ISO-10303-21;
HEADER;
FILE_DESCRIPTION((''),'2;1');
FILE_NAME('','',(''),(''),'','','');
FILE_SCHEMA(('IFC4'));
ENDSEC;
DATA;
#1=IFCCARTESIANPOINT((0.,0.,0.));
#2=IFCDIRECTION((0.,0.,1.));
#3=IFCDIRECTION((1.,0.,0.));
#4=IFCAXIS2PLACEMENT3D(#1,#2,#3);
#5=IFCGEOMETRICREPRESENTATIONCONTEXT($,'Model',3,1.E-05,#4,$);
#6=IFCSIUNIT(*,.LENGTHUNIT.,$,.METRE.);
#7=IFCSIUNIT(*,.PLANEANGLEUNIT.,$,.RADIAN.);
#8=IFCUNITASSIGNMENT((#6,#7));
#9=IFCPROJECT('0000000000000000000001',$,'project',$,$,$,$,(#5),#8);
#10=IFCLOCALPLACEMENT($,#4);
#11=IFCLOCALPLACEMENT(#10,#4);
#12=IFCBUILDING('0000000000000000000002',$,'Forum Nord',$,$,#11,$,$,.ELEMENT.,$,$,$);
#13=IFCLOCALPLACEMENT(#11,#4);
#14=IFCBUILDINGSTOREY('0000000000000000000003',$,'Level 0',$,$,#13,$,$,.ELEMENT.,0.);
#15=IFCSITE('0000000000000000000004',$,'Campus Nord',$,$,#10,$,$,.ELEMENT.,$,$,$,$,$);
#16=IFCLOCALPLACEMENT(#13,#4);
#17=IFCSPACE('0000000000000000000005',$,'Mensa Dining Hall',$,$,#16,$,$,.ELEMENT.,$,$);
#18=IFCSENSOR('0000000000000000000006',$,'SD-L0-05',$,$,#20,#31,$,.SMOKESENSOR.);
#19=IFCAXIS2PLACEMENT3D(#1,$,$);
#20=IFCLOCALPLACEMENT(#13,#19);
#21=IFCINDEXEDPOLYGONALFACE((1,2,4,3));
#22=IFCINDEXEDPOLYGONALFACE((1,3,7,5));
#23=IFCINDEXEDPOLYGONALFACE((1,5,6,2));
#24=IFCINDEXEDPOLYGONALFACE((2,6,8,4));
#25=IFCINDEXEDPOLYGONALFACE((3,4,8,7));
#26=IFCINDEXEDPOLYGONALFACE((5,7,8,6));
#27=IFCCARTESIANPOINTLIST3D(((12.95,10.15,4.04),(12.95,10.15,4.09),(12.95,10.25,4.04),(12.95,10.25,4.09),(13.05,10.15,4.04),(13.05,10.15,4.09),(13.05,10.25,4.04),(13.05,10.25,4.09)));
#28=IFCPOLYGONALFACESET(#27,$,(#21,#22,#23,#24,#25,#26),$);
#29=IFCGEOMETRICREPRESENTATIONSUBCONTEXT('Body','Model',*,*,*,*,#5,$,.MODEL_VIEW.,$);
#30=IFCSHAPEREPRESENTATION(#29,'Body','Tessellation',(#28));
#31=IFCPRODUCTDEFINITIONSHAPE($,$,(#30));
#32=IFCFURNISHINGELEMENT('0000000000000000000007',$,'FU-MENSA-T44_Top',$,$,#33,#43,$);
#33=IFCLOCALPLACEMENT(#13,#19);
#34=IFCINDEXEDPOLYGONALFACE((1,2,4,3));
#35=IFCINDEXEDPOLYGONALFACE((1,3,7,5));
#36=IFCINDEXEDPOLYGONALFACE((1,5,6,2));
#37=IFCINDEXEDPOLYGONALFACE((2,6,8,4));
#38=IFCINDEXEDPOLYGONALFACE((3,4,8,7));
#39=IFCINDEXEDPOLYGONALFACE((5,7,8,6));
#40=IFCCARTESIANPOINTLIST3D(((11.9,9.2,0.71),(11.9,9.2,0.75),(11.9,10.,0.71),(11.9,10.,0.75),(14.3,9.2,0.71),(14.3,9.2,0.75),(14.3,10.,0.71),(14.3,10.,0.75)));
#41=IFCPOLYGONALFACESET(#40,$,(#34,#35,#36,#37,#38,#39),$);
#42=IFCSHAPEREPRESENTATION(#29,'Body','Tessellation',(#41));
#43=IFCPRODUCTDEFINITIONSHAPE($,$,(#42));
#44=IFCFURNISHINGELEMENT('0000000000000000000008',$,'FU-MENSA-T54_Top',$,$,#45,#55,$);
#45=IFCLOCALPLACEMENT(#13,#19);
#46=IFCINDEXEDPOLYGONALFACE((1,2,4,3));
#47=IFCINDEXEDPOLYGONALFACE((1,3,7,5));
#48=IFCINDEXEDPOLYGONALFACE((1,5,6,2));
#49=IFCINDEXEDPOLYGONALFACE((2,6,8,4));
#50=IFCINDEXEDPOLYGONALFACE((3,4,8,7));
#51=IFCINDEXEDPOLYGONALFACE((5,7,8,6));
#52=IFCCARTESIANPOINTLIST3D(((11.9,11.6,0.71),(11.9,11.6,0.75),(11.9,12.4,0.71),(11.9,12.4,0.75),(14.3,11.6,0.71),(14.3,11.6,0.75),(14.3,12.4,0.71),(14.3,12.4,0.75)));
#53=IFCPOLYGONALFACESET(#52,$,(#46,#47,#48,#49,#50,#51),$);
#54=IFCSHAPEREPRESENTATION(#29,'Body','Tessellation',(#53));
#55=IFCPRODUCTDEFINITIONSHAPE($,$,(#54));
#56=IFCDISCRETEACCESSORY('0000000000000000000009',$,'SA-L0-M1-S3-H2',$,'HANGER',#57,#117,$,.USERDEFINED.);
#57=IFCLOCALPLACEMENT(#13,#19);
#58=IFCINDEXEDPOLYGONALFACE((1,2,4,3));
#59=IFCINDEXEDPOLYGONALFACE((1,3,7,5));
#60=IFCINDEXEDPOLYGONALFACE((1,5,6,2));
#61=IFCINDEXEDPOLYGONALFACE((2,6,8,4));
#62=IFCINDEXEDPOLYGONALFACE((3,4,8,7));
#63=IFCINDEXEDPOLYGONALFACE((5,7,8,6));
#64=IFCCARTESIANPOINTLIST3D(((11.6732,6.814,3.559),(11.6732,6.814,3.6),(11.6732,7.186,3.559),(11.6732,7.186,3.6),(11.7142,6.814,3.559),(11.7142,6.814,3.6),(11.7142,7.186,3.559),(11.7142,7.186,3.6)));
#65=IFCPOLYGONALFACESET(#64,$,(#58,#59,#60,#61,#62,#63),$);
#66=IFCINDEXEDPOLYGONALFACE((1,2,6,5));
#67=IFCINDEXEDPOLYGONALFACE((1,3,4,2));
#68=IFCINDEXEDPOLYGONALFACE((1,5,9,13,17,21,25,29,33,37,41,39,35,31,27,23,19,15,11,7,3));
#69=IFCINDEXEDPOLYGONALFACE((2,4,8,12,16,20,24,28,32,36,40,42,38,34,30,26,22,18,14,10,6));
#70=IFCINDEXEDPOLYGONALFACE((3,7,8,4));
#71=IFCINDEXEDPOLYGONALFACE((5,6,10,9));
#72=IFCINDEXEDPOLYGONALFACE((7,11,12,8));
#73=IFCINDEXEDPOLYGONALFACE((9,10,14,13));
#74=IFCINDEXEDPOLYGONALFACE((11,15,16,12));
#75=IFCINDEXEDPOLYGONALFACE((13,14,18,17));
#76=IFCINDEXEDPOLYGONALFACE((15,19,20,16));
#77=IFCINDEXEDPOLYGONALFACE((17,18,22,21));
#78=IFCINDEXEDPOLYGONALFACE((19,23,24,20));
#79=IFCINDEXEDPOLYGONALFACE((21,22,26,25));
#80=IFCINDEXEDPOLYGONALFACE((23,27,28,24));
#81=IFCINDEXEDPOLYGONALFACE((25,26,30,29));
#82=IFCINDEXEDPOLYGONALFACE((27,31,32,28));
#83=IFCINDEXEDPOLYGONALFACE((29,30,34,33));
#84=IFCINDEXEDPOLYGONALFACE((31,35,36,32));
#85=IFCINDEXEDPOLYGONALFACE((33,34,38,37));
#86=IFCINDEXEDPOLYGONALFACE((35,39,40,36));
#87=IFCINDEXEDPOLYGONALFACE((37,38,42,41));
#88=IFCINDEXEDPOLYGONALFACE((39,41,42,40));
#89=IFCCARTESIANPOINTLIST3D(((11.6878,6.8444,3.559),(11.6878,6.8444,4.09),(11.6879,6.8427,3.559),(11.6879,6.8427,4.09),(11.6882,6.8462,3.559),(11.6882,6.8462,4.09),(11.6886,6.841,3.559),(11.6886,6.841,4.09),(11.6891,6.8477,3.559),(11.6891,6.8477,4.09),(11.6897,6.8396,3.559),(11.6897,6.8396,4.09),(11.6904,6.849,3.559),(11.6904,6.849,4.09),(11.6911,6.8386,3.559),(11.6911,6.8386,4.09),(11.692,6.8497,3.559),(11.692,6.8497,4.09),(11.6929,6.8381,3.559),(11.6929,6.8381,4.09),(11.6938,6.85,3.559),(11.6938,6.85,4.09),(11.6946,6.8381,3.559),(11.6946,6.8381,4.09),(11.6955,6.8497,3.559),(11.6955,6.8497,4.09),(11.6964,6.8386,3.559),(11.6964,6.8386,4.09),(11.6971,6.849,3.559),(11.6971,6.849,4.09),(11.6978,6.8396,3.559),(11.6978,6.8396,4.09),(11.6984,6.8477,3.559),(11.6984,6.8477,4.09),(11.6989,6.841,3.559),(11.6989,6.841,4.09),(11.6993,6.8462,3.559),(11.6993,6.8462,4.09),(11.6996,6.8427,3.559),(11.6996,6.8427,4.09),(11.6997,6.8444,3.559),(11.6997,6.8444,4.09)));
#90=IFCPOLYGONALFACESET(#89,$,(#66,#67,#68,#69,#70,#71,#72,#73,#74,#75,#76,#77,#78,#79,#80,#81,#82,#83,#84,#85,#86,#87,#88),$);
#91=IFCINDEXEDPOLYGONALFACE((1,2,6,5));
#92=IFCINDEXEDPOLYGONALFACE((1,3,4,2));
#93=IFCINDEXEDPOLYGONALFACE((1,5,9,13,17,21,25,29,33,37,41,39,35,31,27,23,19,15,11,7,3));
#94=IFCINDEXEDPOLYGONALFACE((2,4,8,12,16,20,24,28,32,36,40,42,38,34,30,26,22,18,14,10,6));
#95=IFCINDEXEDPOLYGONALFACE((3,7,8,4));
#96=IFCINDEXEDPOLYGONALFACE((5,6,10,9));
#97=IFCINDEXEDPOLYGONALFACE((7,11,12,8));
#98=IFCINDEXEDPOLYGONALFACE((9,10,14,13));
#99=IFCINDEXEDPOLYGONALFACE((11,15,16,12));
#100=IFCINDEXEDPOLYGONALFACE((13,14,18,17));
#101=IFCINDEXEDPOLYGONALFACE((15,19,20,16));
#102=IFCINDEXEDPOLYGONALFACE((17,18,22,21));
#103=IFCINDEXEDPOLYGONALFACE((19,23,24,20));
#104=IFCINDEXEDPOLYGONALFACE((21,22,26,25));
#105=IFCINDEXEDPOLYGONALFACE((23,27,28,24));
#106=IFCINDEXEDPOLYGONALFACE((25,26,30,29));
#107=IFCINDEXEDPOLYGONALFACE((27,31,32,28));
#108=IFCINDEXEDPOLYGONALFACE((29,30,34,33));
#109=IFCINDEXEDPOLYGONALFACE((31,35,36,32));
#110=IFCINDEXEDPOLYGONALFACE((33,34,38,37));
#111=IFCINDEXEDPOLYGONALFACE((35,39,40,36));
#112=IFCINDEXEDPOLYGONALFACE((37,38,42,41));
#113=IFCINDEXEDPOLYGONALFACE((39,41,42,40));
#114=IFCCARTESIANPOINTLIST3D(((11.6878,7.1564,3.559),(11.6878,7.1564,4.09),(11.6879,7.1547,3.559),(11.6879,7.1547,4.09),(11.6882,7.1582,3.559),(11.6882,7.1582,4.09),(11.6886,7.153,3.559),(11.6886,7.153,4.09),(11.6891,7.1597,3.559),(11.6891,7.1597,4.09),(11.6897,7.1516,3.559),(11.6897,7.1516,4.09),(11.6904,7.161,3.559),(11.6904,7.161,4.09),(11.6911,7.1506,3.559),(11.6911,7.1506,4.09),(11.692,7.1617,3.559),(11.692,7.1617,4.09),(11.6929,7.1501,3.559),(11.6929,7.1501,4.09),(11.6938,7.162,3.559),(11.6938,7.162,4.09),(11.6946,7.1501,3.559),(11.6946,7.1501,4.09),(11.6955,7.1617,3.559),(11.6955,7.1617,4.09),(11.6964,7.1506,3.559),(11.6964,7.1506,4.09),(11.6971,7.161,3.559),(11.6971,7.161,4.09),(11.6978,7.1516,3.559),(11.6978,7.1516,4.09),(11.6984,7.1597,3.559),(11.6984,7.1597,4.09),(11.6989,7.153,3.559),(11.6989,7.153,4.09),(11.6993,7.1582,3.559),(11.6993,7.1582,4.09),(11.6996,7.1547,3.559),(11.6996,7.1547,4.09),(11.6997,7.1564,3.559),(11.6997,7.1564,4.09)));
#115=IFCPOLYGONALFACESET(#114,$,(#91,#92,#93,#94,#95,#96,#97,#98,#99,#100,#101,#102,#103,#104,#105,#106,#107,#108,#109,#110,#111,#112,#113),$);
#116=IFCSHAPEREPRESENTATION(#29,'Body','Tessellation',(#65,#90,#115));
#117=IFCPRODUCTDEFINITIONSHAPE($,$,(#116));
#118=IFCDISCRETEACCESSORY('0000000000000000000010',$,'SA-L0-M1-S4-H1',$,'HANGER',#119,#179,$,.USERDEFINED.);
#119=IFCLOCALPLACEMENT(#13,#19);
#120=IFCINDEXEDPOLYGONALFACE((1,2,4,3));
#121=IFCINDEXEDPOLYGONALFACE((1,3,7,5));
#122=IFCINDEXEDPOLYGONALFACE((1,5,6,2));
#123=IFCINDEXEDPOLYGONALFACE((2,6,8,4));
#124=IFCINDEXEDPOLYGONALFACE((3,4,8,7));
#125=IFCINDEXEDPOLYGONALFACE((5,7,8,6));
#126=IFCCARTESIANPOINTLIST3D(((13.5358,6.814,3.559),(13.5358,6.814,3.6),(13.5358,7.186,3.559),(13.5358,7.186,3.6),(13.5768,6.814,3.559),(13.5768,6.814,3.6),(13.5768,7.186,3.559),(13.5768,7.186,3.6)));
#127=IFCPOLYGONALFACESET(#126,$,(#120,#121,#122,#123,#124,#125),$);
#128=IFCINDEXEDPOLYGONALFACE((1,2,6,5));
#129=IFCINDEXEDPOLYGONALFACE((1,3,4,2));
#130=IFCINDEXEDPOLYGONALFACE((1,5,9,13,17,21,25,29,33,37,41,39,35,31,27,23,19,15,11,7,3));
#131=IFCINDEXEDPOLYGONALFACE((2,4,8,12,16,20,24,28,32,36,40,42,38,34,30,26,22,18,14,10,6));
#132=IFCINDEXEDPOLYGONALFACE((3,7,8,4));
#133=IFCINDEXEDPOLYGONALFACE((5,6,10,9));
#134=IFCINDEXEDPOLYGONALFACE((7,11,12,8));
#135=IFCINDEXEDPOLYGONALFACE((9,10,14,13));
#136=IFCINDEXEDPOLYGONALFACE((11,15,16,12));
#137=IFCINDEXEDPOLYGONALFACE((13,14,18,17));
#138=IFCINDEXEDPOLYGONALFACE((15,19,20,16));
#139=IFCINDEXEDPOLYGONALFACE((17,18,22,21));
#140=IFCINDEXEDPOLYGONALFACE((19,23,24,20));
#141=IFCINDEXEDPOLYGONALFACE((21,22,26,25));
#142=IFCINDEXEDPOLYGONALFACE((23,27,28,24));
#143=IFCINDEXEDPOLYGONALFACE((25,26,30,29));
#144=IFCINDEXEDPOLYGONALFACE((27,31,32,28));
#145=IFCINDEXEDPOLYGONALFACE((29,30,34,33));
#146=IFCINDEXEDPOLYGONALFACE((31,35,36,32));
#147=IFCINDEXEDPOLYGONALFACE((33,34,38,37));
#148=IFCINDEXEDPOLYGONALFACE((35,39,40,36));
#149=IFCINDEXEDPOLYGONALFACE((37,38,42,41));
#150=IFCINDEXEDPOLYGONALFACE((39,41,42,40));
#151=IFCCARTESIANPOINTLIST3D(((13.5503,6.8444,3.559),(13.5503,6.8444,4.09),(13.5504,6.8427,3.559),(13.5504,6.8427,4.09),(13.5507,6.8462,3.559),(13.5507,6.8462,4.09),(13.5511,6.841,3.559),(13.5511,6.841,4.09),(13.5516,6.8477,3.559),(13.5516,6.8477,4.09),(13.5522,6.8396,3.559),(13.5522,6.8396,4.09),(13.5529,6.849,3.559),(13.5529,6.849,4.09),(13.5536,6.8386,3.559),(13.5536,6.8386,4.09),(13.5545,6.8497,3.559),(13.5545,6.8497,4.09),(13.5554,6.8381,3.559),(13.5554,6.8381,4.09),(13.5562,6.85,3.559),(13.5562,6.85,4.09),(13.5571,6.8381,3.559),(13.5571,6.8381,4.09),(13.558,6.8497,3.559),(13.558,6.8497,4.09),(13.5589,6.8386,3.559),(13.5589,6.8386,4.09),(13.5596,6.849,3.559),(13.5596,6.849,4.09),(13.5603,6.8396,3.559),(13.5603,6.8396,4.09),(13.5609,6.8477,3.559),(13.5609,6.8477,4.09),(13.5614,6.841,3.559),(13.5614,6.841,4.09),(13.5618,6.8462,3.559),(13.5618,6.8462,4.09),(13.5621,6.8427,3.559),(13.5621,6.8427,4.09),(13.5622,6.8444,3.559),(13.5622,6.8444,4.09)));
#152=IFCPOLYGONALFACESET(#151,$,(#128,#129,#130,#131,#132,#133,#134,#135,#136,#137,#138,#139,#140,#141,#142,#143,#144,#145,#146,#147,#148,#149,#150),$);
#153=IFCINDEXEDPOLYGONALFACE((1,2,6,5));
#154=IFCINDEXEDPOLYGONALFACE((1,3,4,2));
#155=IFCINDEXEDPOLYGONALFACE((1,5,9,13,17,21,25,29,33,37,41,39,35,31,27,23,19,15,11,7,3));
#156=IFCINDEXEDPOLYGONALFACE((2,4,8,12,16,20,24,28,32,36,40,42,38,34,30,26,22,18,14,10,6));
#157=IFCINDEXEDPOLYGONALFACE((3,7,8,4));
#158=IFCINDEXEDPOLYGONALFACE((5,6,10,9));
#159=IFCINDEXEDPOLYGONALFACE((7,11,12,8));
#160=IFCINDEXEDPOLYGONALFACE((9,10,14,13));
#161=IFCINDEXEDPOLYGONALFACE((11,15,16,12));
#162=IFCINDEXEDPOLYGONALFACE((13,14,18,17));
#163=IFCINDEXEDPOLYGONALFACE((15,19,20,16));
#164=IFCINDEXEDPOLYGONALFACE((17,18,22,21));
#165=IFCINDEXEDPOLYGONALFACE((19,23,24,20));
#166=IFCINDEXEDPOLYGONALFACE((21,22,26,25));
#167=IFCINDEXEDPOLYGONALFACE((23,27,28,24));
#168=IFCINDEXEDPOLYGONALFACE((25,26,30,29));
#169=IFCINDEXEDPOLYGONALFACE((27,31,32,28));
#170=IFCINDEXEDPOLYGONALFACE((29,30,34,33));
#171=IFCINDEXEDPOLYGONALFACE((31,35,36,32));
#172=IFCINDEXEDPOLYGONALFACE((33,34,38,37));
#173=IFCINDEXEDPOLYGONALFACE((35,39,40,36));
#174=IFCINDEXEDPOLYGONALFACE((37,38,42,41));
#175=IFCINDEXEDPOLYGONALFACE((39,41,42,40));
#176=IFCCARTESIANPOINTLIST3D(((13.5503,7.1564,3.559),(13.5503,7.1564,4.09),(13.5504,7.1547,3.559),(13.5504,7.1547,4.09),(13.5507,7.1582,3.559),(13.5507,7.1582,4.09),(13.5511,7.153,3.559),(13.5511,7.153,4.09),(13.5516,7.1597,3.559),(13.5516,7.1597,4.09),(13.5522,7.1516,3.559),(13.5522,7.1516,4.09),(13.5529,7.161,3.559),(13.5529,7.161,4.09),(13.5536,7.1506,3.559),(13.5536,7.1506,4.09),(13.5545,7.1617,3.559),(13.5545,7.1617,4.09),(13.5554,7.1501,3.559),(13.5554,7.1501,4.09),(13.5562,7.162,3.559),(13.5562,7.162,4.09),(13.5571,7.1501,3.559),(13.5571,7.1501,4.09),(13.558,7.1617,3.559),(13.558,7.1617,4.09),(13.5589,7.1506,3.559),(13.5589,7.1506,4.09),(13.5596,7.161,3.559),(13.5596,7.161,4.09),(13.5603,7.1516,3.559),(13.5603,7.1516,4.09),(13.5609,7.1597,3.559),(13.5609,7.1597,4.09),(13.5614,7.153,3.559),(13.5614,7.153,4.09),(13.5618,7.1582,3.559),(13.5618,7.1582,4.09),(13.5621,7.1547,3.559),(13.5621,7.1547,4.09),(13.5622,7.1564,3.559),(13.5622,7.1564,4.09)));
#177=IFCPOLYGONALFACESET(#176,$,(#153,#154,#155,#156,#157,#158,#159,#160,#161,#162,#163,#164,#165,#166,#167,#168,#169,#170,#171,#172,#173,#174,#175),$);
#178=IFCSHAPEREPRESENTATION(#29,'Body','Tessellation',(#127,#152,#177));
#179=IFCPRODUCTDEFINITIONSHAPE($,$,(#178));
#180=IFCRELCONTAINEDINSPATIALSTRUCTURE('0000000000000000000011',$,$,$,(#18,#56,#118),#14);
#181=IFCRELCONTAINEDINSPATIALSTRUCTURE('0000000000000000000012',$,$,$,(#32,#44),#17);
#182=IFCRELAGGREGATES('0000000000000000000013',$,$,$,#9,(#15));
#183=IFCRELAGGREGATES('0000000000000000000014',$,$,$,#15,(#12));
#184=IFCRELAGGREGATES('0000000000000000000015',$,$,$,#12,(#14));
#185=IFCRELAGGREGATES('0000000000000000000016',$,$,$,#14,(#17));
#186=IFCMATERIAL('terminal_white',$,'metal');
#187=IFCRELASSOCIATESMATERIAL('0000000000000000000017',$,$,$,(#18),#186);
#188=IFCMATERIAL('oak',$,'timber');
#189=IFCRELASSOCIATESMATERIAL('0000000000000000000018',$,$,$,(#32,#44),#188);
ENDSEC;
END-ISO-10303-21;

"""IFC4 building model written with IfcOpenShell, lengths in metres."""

from ifc_helpers import new_model, si_unit, frame, frame_2d, origin_with_axes, origin_2d_with_axis, place, context, subcontext, project, spatial, rectangle, circle, extrude, material, element, save


model = new_model("IFC4")

# Units and contexts
model_context = context("Model", 3, precision=1e-05, world=origin_with_axes())
body_context = subcontext(model_context, "Body", "Model", "MODEL_VIEW")
ifc_project = project(units=[si_unit("LENGTHUNIT", "METRE"), si_unit("PLANEANGLEUNIT", "RADIAN")], contexts=[model_context])

# Site, building, storey
site_placement = place(None, origin_with_axes())
site = spatial("IfcSite", under=ifc_project, at=site_placement, Name="Campus Nord", CompositionType="ELEMENT")
building_placement = place(site_placement, origin_with_axes())
building = spatial("IfcBuilding", under=site, at=building_placement, Name="Forum Nord", CompositionType="ELEMENT")
storey_placement = place(building_placement, origin_with_axes())
storey = spatial("IfcBuildingStorey", under=building, at=storey_placement, Name="Level 0", CompositionType="ELEMENT", Elevation=0.0)

# Shared definitions
ifc_material_1 = material(Name="terminal_white", Category="metal")

# Sensor
sensor_placement = place(storey_placement, frame((13.0, 10.2, 4.04), z_axis=(0.0, 0.0, 1.0), x_axis=(1.0, 0.0, 0.0)))
element("IfcSensor", 1, at=sensor_placement, inside=storey, material=ifc_material_1, Name="SD-L0-05", PredefinedType="SMOKESENSOR", context=body_context, shape_type="SweptSolid", body=[
    extrude(rectangle(XDim=0.1, YDim=0.1, at=origin_2d_with_axis()), origin_with_axes(), (0.0, 0.0, 1.0), 0.05),
])

# Shared definitions
space_placement = place(storey_placement, origin_with_axes())
space = spatial("IfcSpace", under=storey, at=space_placement, Name="Mensa Dining Hall", CompositionType="ELEMENT")

# Furnishing elements
ifc_material_2 = material(Name="oak", Category="timber")
furnishing_1_placement = place(storey_placement, frame((11.9, 9.2, 0.0), z_axis=(0.0, 0.0, 1.0), x_axis=(1.0, 0.0, 0.0)))
element("IfcFurnishingElement", 2, at=furnishing_1_placement, inside=space, material=ifc_material_2, Name="FU-MENSA-T44_Top", context=body_context, shape_type="SweptSolid", body=[
    extrude(rectangle(XDim=2.4, YDim=0.8, at=frame_2d((1.2, 0.4), x_axis=(1.0, 0.0))), frame((0.0, 0.0, 0.71), z_axis=(0.0, 0.0, 1.0), x_axis=(1.0, 0.0, 0.0)), (0.0, 0.0, 1.0), 0.04),
])
furnishing_2_placement = place(storey_placement, frame((11.9, 11.6, 0.0), z_axis=(0.0, 0.0, 1.0), x_axis=(1.0, 0.0, 0.0)))
element("IfcFurnishingElement", 3, at=furnishing_2_placement, inside=space, material=ifc_material_2, Name="FU-MENSA-T54_Top", context=body_context, shape_type="SweptSolid", body=[
    extrude(rectangle(XDim=2.4, YDim=0.8, at=frame_2d((1.2, 0.4), x_axis=(1.0, 0.0))), frame((0.0, 0.0, 0.71), z_axis=(0.0, 0.0, 1.0), x_axis=(1.0, 0.0, 0.0)), (0.0, 0.0, 1.0), 0.04),
])

# Discrete accessories
for number, where, z_axis, x_axis, name in (
    (4, (11.6937, 7.0, 3.6), (0.0, 0.0, 1.0), (0.0, 1.0, 0.0), "SA-L0-M1-S3-H2"),
    (5, (13.5563, 7.0, 3.6), (0.0, 0.0, 1.0), (0.0, 1.0, 0.0), "SA-L0-M1-S4-H1"),
):
    element("IfcDiscreteAccessory", number, at=place(storey_placement, frame(where, z_axis=z_axis, x_axis=x_axis)), inside=storey, Name=name, ObjectType="HANGER", PredefinedType="USERDEFINED", context=body_context, shape_type="SweptSolid", body=[
        extrude(rectangle(XDim=0.372, YDim=0.041, at=origin_2d_with_axis()), frame((0.0, 0.0, -0.041), z_axis=(0.0, 0.0, 1.0), x_axis=(1.0, 0.0, 0.0)), (0.0, 0.0, 1.0), 0.041),
        extrude(circle(Radius=0.006, at=frame_2d((-0.156, 0.0), x_axis=(1.0, 0.0))), frame((0.0, 0.0, -0.041), z_axis=(0.0, 0.0, 1.0), x_axis=(1.0, 0.0, 0.0)), (0.0, 0.0, 1.0), 0.531),
        extrude(circle(Radius=0.006, at=frame_2d((0.156, 0.0), x_axis=(1.0, 0.0))), frame((0.0, 0.0, -0.041), z_axis=(0.0, 0.0, 1.0), x_axis=(1.0, 0.0, 0.0)), (0.0, 0.0, 1.0), 0.531),
    ])

save(model, "model.ifc")
